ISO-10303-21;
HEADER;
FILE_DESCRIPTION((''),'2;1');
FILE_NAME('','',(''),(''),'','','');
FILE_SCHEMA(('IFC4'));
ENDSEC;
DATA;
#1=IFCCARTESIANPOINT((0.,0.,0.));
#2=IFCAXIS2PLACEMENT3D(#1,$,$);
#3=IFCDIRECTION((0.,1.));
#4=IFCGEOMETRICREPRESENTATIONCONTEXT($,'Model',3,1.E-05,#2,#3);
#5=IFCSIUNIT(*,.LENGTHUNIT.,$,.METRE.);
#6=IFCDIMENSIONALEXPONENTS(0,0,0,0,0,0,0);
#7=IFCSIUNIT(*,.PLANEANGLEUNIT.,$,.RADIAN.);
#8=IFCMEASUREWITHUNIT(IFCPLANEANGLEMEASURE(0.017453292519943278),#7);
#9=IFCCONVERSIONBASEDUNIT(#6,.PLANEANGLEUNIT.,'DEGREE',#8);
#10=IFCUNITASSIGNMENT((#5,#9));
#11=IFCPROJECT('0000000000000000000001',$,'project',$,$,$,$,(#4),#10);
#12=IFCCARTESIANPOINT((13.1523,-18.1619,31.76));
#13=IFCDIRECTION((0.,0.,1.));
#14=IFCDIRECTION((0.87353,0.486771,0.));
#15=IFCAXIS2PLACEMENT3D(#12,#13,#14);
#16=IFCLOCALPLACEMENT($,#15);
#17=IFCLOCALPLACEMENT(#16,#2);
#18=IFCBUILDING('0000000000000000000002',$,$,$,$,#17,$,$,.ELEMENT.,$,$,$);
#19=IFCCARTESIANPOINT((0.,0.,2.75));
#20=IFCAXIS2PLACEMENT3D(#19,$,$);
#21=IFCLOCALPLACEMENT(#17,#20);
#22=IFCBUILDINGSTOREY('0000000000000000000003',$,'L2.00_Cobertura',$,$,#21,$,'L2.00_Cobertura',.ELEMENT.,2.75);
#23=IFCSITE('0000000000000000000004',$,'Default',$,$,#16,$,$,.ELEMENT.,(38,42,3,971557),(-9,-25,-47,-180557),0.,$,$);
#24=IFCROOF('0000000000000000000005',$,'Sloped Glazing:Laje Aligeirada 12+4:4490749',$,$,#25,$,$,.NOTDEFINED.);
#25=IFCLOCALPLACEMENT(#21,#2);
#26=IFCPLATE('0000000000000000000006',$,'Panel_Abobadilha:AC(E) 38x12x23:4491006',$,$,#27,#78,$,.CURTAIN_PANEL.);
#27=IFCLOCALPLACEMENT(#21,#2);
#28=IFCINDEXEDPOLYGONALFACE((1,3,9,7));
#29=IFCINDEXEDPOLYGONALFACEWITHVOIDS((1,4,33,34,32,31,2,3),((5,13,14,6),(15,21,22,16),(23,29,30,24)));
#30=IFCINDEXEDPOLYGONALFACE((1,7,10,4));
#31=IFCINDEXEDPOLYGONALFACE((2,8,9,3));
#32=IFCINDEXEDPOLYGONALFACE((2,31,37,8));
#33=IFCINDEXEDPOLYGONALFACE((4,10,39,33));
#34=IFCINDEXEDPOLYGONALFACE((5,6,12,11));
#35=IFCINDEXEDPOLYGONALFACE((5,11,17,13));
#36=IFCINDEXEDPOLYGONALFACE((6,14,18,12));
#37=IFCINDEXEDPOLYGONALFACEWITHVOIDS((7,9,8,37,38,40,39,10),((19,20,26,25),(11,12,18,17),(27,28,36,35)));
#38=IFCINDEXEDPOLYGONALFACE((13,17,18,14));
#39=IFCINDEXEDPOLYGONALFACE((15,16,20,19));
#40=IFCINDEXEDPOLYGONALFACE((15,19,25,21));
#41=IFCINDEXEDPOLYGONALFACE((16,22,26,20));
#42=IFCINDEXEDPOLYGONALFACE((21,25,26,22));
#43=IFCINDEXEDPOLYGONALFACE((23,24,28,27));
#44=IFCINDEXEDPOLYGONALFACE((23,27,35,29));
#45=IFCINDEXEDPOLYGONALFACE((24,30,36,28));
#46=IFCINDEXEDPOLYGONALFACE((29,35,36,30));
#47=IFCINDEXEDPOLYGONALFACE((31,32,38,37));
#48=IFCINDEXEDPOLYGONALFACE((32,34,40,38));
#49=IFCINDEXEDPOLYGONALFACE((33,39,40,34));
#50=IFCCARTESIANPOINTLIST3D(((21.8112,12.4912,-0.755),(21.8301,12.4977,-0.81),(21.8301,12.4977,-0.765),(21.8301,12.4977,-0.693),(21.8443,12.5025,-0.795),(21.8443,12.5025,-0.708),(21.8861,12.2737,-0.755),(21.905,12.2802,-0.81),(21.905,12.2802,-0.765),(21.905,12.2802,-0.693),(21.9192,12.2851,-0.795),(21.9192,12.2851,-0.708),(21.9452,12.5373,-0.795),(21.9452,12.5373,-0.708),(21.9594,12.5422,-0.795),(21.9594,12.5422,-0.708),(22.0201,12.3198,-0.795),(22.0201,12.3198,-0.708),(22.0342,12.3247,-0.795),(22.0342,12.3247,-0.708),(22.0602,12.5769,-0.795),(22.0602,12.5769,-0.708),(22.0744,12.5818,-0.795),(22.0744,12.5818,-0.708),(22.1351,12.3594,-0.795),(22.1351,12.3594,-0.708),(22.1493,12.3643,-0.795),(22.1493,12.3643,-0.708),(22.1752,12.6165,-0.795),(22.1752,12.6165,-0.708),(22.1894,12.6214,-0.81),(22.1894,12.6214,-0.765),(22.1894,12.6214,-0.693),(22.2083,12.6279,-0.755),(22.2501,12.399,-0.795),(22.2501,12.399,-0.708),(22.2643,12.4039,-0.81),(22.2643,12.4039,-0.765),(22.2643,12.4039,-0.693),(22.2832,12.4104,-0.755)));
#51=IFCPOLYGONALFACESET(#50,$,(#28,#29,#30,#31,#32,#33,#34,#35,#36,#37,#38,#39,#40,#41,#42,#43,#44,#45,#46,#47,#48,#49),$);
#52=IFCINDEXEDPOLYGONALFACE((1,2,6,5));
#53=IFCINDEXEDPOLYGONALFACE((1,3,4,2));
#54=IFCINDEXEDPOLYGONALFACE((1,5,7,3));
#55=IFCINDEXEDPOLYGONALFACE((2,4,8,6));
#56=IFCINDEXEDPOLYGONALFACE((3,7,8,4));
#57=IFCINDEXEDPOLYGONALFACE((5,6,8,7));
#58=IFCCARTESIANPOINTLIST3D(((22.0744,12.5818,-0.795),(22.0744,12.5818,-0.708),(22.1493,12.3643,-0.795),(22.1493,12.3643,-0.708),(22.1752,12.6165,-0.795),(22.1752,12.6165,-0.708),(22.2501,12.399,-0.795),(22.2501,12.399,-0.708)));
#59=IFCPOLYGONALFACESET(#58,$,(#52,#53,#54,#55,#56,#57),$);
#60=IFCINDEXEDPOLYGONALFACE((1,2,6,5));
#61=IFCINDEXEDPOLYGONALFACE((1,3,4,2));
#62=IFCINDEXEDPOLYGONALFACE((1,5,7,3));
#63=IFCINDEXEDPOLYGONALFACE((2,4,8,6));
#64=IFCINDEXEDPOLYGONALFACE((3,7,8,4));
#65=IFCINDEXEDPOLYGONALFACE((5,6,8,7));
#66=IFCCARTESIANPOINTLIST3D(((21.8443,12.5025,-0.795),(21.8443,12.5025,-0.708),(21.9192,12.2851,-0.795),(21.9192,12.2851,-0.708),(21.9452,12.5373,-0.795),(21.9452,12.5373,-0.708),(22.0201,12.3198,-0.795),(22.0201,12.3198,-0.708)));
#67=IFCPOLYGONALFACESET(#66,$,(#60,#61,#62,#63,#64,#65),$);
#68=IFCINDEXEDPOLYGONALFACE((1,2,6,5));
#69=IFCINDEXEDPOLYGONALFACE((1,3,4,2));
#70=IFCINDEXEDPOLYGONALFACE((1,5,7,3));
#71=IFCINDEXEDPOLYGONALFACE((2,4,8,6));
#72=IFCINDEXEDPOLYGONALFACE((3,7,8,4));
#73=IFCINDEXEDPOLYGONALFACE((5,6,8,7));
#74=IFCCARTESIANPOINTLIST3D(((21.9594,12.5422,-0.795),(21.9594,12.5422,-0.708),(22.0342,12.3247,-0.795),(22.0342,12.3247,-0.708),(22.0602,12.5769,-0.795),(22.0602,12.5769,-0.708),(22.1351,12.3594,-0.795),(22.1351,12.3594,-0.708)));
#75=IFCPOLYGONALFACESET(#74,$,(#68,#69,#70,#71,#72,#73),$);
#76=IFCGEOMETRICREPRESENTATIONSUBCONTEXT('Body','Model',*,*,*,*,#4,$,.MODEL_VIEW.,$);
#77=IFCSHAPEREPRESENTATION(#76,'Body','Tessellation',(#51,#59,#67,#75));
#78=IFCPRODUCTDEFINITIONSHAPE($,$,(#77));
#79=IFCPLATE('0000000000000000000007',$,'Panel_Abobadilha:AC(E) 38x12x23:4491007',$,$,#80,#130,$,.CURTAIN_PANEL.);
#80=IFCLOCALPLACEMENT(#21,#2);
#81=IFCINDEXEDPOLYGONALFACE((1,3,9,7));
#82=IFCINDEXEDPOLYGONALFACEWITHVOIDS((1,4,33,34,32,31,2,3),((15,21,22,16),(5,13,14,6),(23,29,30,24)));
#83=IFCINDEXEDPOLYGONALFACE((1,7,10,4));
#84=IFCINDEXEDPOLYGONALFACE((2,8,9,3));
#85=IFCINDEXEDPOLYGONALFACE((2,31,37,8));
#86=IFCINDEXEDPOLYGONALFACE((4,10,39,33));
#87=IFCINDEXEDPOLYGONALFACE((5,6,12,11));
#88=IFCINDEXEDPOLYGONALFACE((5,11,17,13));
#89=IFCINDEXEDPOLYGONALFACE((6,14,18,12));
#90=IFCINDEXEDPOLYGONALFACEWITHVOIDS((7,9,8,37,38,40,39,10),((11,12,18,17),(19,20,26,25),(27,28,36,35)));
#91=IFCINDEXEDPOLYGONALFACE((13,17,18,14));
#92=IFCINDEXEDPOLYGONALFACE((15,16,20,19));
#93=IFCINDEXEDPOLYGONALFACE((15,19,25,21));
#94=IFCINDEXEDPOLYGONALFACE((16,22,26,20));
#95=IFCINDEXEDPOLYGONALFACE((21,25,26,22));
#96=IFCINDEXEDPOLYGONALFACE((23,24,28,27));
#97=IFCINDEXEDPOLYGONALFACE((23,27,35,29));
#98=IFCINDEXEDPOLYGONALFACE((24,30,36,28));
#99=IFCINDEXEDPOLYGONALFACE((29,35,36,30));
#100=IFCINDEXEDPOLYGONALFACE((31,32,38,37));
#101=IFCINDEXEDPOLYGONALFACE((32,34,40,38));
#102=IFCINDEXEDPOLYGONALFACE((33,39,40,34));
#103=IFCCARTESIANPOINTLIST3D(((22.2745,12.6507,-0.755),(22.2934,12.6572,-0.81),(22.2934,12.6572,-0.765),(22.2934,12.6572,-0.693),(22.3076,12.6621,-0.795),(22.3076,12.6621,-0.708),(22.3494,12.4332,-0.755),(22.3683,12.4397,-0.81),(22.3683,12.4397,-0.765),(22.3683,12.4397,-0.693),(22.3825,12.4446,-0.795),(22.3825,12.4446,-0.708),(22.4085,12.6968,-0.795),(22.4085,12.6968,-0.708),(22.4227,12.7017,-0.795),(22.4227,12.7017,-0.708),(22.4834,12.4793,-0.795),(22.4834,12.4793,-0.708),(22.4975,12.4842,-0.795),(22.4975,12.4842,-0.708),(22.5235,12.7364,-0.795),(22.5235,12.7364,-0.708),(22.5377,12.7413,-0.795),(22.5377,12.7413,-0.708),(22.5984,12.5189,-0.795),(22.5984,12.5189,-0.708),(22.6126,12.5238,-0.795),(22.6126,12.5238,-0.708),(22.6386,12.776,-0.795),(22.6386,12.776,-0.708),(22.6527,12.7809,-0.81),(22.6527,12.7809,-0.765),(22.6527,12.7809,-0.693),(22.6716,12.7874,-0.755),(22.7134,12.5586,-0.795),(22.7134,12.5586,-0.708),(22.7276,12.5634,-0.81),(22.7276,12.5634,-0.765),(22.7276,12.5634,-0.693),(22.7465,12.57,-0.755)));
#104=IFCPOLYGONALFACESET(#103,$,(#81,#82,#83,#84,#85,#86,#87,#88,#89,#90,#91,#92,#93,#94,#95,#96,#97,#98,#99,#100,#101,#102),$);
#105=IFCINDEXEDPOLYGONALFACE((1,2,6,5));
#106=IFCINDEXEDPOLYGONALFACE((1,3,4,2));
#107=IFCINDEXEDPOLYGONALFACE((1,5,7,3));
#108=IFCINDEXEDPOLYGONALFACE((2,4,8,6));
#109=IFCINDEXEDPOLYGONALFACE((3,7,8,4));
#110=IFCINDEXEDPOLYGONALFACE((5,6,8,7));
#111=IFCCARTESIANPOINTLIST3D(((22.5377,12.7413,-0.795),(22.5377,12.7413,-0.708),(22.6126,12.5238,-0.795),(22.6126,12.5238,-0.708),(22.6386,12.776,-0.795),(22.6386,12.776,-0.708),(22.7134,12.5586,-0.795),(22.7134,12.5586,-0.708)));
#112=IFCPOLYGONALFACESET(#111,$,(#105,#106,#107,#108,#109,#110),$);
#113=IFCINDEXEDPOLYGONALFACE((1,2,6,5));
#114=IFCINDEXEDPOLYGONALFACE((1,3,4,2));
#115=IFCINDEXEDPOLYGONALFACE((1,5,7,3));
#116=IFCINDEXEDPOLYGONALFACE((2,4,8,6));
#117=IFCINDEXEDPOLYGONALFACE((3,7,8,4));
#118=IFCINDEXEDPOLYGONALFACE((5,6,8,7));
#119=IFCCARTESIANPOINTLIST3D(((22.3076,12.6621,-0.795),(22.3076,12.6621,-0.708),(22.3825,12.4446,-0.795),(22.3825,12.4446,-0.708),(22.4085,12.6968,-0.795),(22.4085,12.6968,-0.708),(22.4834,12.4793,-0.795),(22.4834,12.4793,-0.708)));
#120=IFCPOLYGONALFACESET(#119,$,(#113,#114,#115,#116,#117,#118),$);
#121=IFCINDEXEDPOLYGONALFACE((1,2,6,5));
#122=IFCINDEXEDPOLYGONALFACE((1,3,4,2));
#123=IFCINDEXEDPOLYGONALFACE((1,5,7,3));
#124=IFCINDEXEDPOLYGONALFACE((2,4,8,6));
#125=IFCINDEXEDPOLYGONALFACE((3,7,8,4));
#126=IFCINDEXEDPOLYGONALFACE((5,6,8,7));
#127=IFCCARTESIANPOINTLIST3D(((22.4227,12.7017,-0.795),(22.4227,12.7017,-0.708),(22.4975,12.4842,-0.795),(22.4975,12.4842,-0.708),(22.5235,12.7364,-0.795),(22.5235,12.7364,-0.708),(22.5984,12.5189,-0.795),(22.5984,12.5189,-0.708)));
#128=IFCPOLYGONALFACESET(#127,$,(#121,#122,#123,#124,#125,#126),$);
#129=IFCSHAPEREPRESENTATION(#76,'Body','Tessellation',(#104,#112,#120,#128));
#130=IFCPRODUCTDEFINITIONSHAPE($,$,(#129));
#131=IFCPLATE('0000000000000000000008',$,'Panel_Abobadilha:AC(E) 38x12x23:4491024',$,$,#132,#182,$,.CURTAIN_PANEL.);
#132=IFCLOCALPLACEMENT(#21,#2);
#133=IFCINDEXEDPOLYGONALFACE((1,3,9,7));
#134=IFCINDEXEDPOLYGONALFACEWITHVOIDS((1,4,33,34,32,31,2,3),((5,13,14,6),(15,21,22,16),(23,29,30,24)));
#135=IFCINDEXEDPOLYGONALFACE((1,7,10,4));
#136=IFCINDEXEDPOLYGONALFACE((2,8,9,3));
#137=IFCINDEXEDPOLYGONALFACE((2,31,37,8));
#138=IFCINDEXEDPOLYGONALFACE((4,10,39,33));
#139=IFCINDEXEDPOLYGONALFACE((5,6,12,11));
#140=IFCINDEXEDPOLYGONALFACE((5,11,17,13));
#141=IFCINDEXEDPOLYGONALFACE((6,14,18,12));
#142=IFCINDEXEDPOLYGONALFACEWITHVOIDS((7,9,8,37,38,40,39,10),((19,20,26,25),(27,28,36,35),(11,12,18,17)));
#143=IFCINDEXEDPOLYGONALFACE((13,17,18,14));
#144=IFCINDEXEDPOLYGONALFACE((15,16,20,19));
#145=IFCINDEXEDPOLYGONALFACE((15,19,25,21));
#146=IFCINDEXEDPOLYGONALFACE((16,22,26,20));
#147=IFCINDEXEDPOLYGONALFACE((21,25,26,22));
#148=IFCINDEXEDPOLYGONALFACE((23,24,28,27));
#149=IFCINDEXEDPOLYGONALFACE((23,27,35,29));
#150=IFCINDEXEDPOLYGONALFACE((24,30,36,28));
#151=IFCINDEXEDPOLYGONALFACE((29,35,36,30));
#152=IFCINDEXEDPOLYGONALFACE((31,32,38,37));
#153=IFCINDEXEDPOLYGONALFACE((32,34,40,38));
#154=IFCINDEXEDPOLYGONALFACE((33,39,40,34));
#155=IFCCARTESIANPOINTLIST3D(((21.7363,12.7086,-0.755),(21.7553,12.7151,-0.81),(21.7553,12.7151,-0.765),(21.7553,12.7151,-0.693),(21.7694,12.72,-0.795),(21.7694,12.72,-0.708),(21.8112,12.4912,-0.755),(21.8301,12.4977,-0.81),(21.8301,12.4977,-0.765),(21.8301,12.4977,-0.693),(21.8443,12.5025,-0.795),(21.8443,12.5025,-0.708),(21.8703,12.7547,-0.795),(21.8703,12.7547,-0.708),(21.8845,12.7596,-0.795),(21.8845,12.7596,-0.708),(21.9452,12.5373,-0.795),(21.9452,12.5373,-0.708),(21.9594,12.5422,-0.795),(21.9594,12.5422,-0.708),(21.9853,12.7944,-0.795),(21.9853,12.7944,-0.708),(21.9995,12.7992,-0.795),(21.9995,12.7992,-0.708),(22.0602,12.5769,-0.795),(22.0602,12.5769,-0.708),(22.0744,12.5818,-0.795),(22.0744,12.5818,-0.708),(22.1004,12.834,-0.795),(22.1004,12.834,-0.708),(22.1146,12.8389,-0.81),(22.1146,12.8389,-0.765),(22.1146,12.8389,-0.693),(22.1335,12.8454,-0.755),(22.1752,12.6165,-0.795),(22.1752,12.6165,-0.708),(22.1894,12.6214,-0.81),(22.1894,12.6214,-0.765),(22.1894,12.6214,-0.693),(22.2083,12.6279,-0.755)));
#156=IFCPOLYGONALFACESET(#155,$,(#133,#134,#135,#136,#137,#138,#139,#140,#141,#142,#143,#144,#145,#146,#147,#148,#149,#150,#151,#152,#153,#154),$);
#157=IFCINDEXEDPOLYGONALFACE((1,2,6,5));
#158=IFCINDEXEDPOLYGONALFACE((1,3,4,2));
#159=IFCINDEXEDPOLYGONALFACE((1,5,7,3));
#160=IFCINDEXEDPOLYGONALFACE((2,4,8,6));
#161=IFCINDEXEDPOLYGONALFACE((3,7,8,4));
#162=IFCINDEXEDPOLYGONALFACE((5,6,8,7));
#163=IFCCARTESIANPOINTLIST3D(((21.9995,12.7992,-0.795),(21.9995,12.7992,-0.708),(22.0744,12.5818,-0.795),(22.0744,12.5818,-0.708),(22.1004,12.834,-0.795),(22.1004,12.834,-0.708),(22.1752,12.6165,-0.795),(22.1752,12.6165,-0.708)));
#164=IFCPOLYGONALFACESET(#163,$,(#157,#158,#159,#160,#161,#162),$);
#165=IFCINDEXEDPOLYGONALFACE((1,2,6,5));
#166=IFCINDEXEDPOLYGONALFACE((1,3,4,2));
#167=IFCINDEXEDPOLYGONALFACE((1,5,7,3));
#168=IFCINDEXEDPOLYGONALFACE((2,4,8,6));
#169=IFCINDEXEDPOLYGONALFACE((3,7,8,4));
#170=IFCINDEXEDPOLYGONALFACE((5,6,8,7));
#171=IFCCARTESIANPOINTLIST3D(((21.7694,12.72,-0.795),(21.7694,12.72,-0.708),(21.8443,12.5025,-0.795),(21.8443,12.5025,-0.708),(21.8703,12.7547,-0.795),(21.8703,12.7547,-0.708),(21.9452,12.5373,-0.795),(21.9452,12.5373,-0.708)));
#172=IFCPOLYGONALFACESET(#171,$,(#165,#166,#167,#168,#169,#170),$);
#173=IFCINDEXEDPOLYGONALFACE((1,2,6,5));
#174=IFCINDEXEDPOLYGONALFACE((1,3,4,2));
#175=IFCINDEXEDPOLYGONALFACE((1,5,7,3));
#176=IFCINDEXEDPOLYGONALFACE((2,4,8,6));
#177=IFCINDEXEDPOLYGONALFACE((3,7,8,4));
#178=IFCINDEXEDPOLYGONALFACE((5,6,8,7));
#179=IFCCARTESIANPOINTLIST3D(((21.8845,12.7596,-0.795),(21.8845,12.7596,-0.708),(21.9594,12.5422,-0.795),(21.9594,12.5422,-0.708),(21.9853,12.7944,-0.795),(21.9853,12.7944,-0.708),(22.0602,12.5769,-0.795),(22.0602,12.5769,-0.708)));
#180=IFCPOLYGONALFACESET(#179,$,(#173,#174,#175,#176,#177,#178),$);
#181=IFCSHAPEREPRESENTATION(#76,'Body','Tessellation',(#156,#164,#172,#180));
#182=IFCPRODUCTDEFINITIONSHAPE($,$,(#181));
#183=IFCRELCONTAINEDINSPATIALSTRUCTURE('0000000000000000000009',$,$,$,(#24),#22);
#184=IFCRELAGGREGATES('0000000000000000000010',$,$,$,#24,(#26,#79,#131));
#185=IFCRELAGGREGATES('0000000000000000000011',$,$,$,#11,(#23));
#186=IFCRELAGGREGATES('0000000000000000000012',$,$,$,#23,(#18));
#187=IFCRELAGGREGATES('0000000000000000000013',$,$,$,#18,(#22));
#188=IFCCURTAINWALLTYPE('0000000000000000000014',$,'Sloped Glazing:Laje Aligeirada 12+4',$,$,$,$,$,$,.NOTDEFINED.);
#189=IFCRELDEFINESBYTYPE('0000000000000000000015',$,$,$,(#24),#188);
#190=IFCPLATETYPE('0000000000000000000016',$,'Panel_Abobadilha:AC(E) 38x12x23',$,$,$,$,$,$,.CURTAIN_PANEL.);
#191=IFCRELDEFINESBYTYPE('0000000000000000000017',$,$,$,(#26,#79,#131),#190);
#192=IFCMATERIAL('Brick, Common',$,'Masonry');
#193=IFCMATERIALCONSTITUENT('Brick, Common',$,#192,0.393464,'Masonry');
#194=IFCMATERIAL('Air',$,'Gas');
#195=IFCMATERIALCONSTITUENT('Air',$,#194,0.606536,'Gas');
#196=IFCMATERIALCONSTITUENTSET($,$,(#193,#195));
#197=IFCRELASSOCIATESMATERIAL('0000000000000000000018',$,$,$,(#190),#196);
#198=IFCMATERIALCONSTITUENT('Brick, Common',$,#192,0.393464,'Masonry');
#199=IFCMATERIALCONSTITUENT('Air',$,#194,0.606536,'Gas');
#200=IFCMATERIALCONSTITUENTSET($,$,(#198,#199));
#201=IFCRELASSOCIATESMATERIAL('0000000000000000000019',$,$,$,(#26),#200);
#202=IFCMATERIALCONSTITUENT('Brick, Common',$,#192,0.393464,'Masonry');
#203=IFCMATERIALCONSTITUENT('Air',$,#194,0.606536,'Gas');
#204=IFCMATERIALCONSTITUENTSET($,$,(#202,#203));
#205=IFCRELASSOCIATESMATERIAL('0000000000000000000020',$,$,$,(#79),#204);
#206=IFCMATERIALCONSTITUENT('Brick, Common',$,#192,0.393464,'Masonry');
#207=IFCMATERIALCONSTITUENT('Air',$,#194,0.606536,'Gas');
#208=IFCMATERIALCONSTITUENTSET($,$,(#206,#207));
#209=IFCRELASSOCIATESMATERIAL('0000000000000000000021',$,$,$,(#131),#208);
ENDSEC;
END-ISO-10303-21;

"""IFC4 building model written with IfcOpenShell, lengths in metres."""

from ifc_helpers import new_model, entity, si_unit, converted_unit, direction, frame, origin, place, context, subcontext, project, spatial, indexed_curve, outline, extrude, source, transform, mapped, material, constituent, constituent_set, type_object, type_shapes, element, aggregate, save


model = new_model("IFC4")

# Units and contexts
model_context = context("Model", 3, precision=1e-05, world=origin(), true_north=direction((0.0, 1.0)))
body_context = subcontext(model_context, "Body", "Model", "MODEL_VIEW")
ifc_project = project(units=[si_unit("LENGTHUNIT", "METRE"), converted_unit("PLANEANGLEUNIT", "DEGREE", entity("IfcPlaneAngleMeasure", 0.017453292519943278), si_unit("PLANEANGLEUNIT", "RADIAN"), dimensions=[0, 0, 0, 0, 0, 0, 0])], contexts=[model_context])

# Site, building, storey
site_placement = place(None, frame((13.1523, -18.1619, 31.76), z_axis=(0.0, 0.0, 1.0), x_axis=(0.87353, 0.486771, 0.0)))
site = spatial("IfcSite", under=ifc_project, at=site_placement, Name="Default", CompositionType="ELEMENT", RefLatitude=(38, 42, 3, 971557), RefLongitude=(-9, -25, -47, -180557), RefElevation=0.0)
building_placement = place(site_placement, origin())
building = spatial("IfcBuilding", under=site, at=building_placement, CompositionType="ELEMENT")
storey_placement = place(building_placement, frame((0.0, 0.0, 2.75)))
storey = spatial("IfcBuildingStorey", under=building, at=storey_placement, Name="L2.00_Cobertura", LongName="L2.00_Cobertura", CompositionType="ELEMENT", Elevation=2.75)

# Roof, plates
curtain_wall_type = type_object("IfcCurtainWallType", Name="Sloped Glazing:Laje Aligeirada 12+4", PredefinedType="NOTDEFINED")
roof_placement = place(storey_placement, frame((0.0, 0.0, -2.75)))
roof = element("IfcRoof", 1, at=roof_placement, inside=storey, type_object=curtain_wall_type, Name="Sloped Glazing:Laje Aligeirada 12+4:4490749", PredefinedType="NOTDEFINED")
ifc_material_1 = material(Name="Brick, Common", Category="Masonry")
ifc_material_2 = material(Name="Air", Category="Gas")
ifc_constituent_1 = constituent(ifc_material_1, Name="Brick, Common", Category="Masonry", fraction=0.393464)
ifc_constituent_2 = constituent(ifc_material_2, Name="Air", Category="Gas", fraction=0.606536)
ifc_constituent_set_1 = constituent_set(constituents=[ifc_constituent_1, ifc_constituent_2])
plate_type = type_object("IfcPlateType", Name="Panel_Abobadilha:AC(E) 38x12x23", PredefinedType="CURTAIN_PANEL", material=ifc_constituent_set_1)
shared_shape_1 = source(origin(), body_context, "Body", "SweptSolid", [
    extrude(outline(indexed_curve([(-0.19, -0.0543), (0.19, -0.0543), (0.19, -0.0093), (0.21, 0.0007), (0.19, 0.0628), (-0.19, 0.0628), (-0.21, 0.0007), (-0.19, -0.0093), (-0.19, -0.0543)], self_intersect=False), holes=[indexed_curve([(-0.0683, 0.0477), (-0.0683, -0.0393), (-0.175, -0.0393), (-0.175, 0.0477), (-0.0683, 0.0477)], self_intersect=False), indexed_curve([(0.0533, 0.0477), (0.0533, -0.0393), (-0.0533, -0.0393), (-0.0533, 0.0477), (0.0533, 0.0477)], self_intersect=False), indexed_curve([(0.175, 0.0477), (0.175, -0.0393), (0.0683, -0.0393), (0.0683, 0.0477), (0.175, 0.0477)], self_intersect=False)]), frame((0.0, 0.0543, 0.0)), (0.0, 0.0, 1.0), 0.23),
    extrude(outline(indexed_curve([(-0.0533, -0.0435), (0.0533, -0.0435), (0.0533, 0.0435), (-0.0533, 0.0435), (-0.0533, -0.0435)], self_intersect=False)), frame((0.1217, 0.0585, 0.0), z_axis=(0.0, 0.0, 1.0), x_axis=(-1.0, 0.0, 0.0)), (0.0, 0.0, 1.0), 0.23),
    extrude(outline(indexed_curve([(-0.0533, -0.0435), (0.0533, -0.0435), (0.0533, 0.0435), (-0.0533, 0.0435), (-0.0533, -0.0435)], self_intersect=False)), frame((-0.1217, 0.0585, 0.0), z_axis=(0.0, 0.0, 1.0), x_axis=(-1.0, 0.0, 0.0)), (0.0, 0.0, 1.0), 0.23),
    extrude(outline(indexed_curve([(-0.0533, -0.0435), (0.0533, -0.0435), (0.0533, 0.0435), (-0.0533, 0.0435), (-0.0533, -0.0435)], self_intersect=False)), frame((0.0, 0.0585, 0.0), z_axis=(0.0, 0.0, 1.0), x_axis=(-1.0, 0.0, 0.0)), (0.0, 0.0, 1.0), 0.23),
])
type_shapes(plate_type, [shared_shape_1])
ifc_constituent_3 = constituent(ifc_material_1, Name="Brick, Common", Category="Masonry", fraction=0.393464)
ifc_constituent_4 = constituent(ifc_material_2, Name="Air", Category="Gas", fraction=0.606536)
ifc_constituent_set_2 = constituent_set(constituents=[ifc_constituent_3, ifc_constituent_4])
plate_1_placement = place(roof_placement, frame((22.0098, 12.5595, 1.94), z_axis=(0.325568, -0.945519, 0.0), x_axis=(0.945519, 0.325568, 0.0)))
plate_1 = element("IfcPlate", 2, at=plate_1_placement, type_object=plate_type, material=ifc_constituent_set_2, Name="Panel_Abobadilha:AC(E) 38x12x23:4491006", PredefinedType="CURTAIN_PANEL", context=body_context, shape_type="MappedRepresentation", body=[
    mapped(shared_shape_1, transform((0.0, 0.0, 0.0), scale=1.0)),
])
ifc_constituent_5 = constituent(ifc_material_1, Name="Brick, Common", Category="Masonry", fraction=0.393464)
ifc_constituent_6 = constituent(ifc_material_2, Name="Air", Category="Gas", fraction=0.606536)
ifc_constituent_set_3 = constituent_set(constituents=[ifc_constituent_5, ifc_constituent_6])
plate_2_placement = place(roof_placement, frame((22.4731, 12.7191, 1.94), z_axis=(0.325568, -0.945519, 0.0), x_axis=(0.945519, 0.325568, 0.0)))
plate_2 = element("IfcPlate", 3, at=plate_2_placement, type_object=plate_type, material=ifc_constituent_set_3, Name="Panel_Abobadilha:AC(E) 38x12x23:4491007", PredefinedType="CURTAIN_PANEL", context=body_context, shape_type="MappedRepresentation", body=[
    mapped(shared_shape_1, transform((0.0, 0.0, 0.0), scale=1.0)),
])
ifc_constituent_7 = constituent(ifc_material_1, Name="Brick, Common", Category="Masonry", fraction=0.393464)
ifc_constituent_8 = constituent(ifc_material_2, Name="Air", Category="Gas", fraction=0.606536)
ifc_constituent_set_4 = constituent_set(constituents=[ifc_constituent_7, ifc_constituent_8])
plate_3_placement = place(roof_placement, frame((21.9349, 12.777, 1.94), z_axis=(0.325568, -0.945519, 0.0), x_axis=(0.945519, 0.325568, 0.0)))
plate_3 = element("IfcPlate", 4, at=plate_3_placement, type_object=plate_type, material=ifc_constituent_set_4, Name="Panel_Abobadilha:AC(E) 38x12x23:4491024", PredefinedType="CURTAIN_PANEL", context=body_context, shape_type="MappedRepresentation", body=[
    mapped(shared_shape_1, transform((0.0, 0.0, 0.0), scale=1.0)),
])
aggregate(roof, [plate_1, plate_2, plate_3])

save(model, "model.ifc")
